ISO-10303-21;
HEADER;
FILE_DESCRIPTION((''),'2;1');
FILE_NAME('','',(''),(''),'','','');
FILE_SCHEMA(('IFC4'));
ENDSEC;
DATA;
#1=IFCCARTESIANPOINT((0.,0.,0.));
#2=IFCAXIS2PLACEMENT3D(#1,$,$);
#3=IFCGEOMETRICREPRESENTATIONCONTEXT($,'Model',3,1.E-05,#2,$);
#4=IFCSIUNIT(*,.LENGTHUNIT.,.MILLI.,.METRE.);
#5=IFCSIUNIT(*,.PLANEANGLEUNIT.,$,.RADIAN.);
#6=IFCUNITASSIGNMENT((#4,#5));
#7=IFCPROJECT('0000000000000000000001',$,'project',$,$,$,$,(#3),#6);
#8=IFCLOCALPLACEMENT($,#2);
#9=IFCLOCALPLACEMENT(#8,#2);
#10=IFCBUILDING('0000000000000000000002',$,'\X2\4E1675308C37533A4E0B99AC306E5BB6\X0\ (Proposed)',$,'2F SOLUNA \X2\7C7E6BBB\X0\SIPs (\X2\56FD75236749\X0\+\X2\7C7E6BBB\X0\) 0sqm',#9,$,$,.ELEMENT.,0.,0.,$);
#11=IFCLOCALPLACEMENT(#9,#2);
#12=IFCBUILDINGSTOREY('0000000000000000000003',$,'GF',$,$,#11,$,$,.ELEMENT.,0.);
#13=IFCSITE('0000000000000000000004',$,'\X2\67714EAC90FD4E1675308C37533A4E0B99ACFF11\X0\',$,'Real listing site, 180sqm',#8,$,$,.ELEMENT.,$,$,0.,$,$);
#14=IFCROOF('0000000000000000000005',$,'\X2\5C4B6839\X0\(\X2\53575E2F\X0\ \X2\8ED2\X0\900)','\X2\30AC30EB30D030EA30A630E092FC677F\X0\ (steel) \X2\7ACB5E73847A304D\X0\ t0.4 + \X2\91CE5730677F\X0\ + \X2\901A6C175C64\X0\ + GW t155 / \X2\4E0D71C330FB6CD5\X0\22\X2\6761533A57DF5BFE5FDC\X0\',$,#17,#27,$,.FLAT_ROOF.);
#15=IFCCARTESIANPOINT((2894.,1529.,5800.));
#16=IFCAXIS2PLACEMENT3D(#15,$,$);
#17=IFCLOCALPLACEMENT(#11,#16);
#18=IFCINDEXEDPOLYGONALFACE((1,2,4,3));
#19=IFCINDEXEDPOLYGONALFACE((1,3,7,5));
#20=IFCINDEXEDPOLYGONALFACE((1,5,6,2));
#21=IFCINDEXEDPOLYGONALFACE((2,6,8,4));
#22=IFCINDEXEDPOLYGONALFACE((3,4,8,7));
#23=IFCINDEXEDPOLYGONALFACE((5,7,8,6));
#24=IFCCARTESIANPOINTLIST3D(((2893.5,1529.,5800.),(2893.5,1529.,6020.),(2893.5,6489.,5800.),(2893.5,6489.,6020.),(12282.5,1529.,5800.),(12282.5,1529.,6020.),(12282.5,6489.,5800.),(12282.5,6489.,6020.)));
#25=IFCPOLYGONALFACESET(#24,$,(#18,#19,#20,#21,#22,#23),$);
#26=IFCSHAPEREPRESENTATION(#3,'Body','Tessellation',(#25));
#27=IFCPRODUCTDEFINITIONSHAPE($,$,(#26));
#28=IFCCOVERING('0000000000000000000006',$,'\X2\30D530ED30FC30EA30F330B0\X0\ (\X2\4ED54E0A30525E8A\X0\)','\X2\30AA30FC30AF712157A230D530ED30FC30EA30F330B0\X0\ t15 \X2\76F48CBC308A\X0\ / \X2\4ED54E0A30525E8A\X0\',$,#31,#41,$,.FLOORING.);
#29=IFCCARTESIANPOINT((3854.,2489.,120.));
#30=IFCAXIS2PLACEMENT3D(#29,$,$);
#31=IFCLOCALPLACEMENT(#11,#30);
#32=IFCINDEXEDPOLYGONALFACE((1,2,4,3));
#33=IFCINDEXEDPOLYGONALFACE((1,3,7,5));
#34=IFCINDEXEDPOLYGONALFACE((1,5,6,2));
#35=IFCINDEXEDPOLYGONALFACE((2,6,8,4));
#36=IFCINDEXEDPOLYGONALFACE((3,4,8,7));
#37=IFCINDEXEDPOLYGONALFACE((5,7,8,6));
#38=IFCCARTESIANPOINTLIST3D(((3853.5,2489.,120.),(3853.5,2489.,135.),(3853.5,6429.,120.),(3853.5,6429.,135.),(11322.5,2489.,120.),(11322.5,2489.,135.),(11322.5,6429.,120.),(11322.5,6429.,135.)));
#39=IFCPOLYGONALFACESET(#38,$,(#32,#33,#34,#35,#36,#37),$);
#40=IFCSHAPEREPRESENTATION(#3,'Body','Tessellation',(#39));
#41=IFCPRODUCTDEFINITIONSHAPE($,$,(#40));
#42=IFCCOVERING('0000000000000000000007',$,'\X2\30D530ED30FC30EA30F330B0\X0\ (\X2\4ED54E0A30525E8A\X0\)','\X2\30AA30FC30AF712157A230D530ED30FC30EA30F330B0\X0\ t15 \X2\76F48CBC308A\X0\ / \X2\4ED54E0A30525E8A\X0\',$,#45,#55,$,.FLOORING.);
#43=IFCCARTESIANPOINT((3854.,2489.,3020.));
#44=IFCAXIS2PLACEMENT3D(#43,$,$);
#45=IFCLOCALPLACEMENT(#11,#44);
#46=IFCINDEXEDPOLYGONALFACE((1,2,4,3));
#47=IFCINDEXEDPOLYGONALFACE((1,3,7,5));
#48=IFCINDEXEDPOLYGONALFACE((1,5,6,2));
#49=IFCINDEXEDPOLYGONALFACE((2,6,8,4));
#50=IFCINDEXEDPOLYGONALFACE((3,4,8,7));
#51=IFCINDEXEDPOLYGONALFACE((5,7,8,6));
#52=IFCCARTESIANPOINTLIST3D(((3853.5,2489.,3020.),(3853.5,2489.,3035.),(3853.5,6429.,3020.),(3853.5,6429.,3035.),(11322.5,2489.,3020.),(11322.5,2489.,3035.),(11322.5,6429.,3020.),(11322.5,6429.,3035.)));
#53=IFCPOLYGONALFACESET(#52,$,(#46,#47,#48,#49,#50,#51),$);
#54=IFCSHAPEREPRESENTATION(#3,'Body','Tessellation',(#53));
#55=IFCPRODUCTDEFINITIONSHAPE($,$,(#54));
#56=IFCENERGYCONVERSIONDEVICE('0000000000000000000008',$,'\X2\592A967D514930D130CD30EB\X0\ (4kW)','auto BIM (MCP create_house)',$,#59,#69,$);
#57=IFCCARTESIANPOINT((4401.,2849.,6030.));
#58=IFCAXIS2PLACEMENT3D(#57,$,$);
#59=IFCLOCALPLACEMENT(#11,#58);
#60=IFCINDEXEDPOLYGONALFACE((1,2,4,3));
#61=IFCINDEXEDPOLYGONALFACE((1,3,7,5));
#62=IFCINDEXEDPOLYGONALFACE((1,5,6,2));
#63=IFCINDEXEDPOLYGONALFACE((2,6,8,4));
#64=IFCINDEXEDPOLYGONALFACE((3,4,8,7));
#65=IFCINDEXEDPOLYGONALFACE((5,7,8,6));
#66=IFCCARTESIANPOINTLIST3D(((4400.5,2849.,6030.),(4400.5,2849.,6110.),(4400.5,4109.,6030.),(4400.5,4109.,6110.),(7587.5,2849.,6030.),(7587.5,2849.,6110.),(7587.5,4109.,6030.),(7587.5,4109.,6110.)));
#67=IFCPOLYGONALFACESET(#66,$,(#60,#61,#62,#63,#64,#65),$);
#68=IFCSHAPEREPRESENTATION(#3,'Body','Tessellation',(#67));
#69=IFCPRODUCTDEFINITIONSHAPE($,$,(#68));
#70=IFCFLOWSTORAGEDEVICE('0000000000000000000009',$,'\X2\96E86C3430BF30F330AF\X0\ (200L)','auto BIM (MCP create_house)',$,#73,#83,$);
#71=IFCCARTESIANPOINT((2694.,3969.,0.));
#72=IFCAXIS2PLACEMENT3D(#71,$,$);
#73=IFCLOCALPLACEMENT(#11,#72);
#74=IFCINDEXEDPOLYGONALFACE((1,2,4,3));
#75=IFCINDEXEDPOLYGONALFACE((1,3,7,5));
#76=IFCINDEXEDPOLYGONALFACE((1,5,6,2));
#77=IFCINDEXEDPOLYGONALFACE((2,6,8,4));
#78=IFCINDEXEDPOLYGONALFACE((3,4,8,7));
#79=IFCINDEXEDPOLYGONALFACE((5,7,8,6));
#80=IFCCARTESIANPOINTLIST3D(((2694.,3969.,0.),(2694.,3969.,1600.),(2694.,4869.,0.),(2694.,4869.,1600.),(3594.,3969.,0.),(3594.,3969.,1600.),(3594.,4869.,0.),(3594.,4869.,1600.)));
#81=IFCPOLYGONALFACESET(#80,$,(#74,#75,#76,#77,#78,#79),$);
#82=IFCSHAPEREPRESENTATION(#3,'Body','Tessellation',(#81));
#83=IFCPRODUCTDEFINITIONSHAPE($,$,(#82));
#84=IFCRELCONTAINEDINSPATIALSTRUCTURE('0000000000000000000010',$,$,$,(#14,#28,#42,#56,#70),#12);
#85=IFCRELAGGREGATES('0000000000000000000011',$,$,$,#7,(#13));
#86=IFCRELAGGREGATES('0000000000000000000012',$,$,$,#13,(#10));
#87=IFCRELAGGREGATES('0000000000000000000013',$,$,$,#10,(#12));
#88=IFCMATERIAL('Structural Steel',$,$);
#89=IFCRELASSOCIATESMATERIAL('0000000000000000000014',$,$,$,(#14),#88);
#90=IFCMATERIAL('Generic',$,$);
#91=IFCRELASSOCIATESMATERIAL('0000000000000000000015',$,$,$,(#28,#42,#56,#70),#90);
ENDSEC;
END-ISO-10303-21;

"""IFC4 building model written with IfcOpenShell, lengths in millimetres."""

from ifc_helpers import new_model, si_unit, frame, frame_2d, origin, place, context, project, spatial, rectangle, extrude, material, element, save


model = new_model("IFC4")

# Units and contexts
model_context = context("Model", 3, precision=1e-05, world=origin())
ifc_project = project(units=[si_unit("LENGTHUNIT", "METRE", prefix="MILLI"), si_unit("PLANEANGLEUNIT", "RADIAN")], contexts=[model_context])

# Site, building, storey
site_placement = place(None, origin())
site = spatial("IfcSite", under=ifc_project, at=site_placement, Name="東京都世田谷区下馬１", ObjectType="Real listing site, 180sqm", CompositionType="ELEMENT", RefElevation=0.0)
building_placement = place(site_placement, origin())
building = spatial("IfcBuilding", under=site, at=building_placement, Name="世田谷区下馬の家 (Proposed)", ObjectType="2F SOLUNA 籾殻SIPs (国産杉+籾殻) 0sqm", CompositionType="ELEMENT", ElevationOfRefHeight=0.0, ElevationOfTerrain=0.0)
storey_placement = place(building_placement, origin())
storey = spatial("IfcBuildingStorey", under=building, at=storey_placement, Name="GF", CompositionType="ELEMENT", Elevation=0.0)

# Roof
ifc_material_1 = material(Name="Structural Steel")
for number, where, name in (
    (1, (2894.0, 1529.0, 5800.0), "屋根(南帯 軒900)"),
):
    element("IfcRoof", number, at=place(storey_placement, frame(where)), inside=storey, material=ifc_material_1, Name=name, Description="ガルバリウム鋼板 (steel) 立平葺き t0.4 + 野地板 + 通気層 + GW t155 / 不燃・法22条区域対応", PredefinedType="FLAT_ROOF", context=model_context, shape_type="SweptSolid", body=[
        extrude(rectangle(XDim=9389.0, YDim=4960.0, at=frame_2d((4694.0, 2480.0))), frame((2894.0, 1529.0, 5800.0)), (0.0, 0.0, 1.0), 220.0),
    ])

# Coverings
ifc_material_2 = material(Name="Generic")
covering_1_placement = place(storey_placement, frame((3854.0, 2489.0, 120.0)))
element("IfcCovering", 2, at=covering_1_placement, inside=storey, material=ifc_material_2, Name="フローリング (仕上げ床)", Description="オーク無垢フローリング t15 直貼り / 仕上げ床", PredefinedType="FLOORING", context=model_context, shape_type="SweptSolid", body=[
    extrude(rectangle(XDim=7469.0, YDim=3940.0, at=frame_2d((3734.0, 1970.0))), frame((3854.0, 2489.0, 120.0)), (0.0, 0.0, 1.0), 15.0),
])
covering_2_placement = place(storey_placement, frame((3854.0, 2489.0, 3020.0)))
element("IfcCovering", 3, at=covering_2_placement, inside=storey, material=ifc_material_2, Name="フローリング (仕上げ床)", Description="オーク無垢フローリング t15 直貼り / 仕上げ床", PredefinedType="FLOORING", context=model_context, shape_type="SweptSolid", body=[
    extrude(rectangle(XDim=7469.0, YDim=3940.0, at=frame_2d((3734.0, 1970.0))), frame((3854.0, 2489.0, 3020.0)), (0.0, 0.0, 1.0), 15.0),
])

# Energy conversion device
energy_conversion_device_placement = place(storey_placement, frame((4401.0, 2849.0, 6030.0)))
element("IfcEnergyConversionDevice", 4, at=energy_conversion_device_placement, inside=storey, material=ifc_material_2, Name="太陽光パネル (4kW)", Description="auto BIM (MCP create_house)", context=model_context, shape_type="SweptSolid", body=[
    extrude(rectangle(XDim=3187.0, YDim=1260.0, at=frame_2d((1593.0, 630.0))), frame((4401.0, 2849.0, 6030.0)), (0.0, 0.0, 1.0), 80.0),
])

# Flow storage device
flow_storage_device_placement = place(storey_placement, frame((2694.0, 3969.0, 0.0)))
element("IfcFlowStorageDevice", 5, at=flow_storage_device_placement, inside=storey, material=ifc_material_2, Name="雨水タンク (200L)", Description="auto BIM (MCP create_house)", context=model_context, shape_type="SweptSolid", body=[
    extrude(rectangle(XDim=900.0, YDim=900.0, at=frame_2d((450.0, 450.0))), frame((2694.0, 3969.0, 0.0)), (0.0, 0.0, 1.0), 1600.0),
])

save(model, "model.ifc")
